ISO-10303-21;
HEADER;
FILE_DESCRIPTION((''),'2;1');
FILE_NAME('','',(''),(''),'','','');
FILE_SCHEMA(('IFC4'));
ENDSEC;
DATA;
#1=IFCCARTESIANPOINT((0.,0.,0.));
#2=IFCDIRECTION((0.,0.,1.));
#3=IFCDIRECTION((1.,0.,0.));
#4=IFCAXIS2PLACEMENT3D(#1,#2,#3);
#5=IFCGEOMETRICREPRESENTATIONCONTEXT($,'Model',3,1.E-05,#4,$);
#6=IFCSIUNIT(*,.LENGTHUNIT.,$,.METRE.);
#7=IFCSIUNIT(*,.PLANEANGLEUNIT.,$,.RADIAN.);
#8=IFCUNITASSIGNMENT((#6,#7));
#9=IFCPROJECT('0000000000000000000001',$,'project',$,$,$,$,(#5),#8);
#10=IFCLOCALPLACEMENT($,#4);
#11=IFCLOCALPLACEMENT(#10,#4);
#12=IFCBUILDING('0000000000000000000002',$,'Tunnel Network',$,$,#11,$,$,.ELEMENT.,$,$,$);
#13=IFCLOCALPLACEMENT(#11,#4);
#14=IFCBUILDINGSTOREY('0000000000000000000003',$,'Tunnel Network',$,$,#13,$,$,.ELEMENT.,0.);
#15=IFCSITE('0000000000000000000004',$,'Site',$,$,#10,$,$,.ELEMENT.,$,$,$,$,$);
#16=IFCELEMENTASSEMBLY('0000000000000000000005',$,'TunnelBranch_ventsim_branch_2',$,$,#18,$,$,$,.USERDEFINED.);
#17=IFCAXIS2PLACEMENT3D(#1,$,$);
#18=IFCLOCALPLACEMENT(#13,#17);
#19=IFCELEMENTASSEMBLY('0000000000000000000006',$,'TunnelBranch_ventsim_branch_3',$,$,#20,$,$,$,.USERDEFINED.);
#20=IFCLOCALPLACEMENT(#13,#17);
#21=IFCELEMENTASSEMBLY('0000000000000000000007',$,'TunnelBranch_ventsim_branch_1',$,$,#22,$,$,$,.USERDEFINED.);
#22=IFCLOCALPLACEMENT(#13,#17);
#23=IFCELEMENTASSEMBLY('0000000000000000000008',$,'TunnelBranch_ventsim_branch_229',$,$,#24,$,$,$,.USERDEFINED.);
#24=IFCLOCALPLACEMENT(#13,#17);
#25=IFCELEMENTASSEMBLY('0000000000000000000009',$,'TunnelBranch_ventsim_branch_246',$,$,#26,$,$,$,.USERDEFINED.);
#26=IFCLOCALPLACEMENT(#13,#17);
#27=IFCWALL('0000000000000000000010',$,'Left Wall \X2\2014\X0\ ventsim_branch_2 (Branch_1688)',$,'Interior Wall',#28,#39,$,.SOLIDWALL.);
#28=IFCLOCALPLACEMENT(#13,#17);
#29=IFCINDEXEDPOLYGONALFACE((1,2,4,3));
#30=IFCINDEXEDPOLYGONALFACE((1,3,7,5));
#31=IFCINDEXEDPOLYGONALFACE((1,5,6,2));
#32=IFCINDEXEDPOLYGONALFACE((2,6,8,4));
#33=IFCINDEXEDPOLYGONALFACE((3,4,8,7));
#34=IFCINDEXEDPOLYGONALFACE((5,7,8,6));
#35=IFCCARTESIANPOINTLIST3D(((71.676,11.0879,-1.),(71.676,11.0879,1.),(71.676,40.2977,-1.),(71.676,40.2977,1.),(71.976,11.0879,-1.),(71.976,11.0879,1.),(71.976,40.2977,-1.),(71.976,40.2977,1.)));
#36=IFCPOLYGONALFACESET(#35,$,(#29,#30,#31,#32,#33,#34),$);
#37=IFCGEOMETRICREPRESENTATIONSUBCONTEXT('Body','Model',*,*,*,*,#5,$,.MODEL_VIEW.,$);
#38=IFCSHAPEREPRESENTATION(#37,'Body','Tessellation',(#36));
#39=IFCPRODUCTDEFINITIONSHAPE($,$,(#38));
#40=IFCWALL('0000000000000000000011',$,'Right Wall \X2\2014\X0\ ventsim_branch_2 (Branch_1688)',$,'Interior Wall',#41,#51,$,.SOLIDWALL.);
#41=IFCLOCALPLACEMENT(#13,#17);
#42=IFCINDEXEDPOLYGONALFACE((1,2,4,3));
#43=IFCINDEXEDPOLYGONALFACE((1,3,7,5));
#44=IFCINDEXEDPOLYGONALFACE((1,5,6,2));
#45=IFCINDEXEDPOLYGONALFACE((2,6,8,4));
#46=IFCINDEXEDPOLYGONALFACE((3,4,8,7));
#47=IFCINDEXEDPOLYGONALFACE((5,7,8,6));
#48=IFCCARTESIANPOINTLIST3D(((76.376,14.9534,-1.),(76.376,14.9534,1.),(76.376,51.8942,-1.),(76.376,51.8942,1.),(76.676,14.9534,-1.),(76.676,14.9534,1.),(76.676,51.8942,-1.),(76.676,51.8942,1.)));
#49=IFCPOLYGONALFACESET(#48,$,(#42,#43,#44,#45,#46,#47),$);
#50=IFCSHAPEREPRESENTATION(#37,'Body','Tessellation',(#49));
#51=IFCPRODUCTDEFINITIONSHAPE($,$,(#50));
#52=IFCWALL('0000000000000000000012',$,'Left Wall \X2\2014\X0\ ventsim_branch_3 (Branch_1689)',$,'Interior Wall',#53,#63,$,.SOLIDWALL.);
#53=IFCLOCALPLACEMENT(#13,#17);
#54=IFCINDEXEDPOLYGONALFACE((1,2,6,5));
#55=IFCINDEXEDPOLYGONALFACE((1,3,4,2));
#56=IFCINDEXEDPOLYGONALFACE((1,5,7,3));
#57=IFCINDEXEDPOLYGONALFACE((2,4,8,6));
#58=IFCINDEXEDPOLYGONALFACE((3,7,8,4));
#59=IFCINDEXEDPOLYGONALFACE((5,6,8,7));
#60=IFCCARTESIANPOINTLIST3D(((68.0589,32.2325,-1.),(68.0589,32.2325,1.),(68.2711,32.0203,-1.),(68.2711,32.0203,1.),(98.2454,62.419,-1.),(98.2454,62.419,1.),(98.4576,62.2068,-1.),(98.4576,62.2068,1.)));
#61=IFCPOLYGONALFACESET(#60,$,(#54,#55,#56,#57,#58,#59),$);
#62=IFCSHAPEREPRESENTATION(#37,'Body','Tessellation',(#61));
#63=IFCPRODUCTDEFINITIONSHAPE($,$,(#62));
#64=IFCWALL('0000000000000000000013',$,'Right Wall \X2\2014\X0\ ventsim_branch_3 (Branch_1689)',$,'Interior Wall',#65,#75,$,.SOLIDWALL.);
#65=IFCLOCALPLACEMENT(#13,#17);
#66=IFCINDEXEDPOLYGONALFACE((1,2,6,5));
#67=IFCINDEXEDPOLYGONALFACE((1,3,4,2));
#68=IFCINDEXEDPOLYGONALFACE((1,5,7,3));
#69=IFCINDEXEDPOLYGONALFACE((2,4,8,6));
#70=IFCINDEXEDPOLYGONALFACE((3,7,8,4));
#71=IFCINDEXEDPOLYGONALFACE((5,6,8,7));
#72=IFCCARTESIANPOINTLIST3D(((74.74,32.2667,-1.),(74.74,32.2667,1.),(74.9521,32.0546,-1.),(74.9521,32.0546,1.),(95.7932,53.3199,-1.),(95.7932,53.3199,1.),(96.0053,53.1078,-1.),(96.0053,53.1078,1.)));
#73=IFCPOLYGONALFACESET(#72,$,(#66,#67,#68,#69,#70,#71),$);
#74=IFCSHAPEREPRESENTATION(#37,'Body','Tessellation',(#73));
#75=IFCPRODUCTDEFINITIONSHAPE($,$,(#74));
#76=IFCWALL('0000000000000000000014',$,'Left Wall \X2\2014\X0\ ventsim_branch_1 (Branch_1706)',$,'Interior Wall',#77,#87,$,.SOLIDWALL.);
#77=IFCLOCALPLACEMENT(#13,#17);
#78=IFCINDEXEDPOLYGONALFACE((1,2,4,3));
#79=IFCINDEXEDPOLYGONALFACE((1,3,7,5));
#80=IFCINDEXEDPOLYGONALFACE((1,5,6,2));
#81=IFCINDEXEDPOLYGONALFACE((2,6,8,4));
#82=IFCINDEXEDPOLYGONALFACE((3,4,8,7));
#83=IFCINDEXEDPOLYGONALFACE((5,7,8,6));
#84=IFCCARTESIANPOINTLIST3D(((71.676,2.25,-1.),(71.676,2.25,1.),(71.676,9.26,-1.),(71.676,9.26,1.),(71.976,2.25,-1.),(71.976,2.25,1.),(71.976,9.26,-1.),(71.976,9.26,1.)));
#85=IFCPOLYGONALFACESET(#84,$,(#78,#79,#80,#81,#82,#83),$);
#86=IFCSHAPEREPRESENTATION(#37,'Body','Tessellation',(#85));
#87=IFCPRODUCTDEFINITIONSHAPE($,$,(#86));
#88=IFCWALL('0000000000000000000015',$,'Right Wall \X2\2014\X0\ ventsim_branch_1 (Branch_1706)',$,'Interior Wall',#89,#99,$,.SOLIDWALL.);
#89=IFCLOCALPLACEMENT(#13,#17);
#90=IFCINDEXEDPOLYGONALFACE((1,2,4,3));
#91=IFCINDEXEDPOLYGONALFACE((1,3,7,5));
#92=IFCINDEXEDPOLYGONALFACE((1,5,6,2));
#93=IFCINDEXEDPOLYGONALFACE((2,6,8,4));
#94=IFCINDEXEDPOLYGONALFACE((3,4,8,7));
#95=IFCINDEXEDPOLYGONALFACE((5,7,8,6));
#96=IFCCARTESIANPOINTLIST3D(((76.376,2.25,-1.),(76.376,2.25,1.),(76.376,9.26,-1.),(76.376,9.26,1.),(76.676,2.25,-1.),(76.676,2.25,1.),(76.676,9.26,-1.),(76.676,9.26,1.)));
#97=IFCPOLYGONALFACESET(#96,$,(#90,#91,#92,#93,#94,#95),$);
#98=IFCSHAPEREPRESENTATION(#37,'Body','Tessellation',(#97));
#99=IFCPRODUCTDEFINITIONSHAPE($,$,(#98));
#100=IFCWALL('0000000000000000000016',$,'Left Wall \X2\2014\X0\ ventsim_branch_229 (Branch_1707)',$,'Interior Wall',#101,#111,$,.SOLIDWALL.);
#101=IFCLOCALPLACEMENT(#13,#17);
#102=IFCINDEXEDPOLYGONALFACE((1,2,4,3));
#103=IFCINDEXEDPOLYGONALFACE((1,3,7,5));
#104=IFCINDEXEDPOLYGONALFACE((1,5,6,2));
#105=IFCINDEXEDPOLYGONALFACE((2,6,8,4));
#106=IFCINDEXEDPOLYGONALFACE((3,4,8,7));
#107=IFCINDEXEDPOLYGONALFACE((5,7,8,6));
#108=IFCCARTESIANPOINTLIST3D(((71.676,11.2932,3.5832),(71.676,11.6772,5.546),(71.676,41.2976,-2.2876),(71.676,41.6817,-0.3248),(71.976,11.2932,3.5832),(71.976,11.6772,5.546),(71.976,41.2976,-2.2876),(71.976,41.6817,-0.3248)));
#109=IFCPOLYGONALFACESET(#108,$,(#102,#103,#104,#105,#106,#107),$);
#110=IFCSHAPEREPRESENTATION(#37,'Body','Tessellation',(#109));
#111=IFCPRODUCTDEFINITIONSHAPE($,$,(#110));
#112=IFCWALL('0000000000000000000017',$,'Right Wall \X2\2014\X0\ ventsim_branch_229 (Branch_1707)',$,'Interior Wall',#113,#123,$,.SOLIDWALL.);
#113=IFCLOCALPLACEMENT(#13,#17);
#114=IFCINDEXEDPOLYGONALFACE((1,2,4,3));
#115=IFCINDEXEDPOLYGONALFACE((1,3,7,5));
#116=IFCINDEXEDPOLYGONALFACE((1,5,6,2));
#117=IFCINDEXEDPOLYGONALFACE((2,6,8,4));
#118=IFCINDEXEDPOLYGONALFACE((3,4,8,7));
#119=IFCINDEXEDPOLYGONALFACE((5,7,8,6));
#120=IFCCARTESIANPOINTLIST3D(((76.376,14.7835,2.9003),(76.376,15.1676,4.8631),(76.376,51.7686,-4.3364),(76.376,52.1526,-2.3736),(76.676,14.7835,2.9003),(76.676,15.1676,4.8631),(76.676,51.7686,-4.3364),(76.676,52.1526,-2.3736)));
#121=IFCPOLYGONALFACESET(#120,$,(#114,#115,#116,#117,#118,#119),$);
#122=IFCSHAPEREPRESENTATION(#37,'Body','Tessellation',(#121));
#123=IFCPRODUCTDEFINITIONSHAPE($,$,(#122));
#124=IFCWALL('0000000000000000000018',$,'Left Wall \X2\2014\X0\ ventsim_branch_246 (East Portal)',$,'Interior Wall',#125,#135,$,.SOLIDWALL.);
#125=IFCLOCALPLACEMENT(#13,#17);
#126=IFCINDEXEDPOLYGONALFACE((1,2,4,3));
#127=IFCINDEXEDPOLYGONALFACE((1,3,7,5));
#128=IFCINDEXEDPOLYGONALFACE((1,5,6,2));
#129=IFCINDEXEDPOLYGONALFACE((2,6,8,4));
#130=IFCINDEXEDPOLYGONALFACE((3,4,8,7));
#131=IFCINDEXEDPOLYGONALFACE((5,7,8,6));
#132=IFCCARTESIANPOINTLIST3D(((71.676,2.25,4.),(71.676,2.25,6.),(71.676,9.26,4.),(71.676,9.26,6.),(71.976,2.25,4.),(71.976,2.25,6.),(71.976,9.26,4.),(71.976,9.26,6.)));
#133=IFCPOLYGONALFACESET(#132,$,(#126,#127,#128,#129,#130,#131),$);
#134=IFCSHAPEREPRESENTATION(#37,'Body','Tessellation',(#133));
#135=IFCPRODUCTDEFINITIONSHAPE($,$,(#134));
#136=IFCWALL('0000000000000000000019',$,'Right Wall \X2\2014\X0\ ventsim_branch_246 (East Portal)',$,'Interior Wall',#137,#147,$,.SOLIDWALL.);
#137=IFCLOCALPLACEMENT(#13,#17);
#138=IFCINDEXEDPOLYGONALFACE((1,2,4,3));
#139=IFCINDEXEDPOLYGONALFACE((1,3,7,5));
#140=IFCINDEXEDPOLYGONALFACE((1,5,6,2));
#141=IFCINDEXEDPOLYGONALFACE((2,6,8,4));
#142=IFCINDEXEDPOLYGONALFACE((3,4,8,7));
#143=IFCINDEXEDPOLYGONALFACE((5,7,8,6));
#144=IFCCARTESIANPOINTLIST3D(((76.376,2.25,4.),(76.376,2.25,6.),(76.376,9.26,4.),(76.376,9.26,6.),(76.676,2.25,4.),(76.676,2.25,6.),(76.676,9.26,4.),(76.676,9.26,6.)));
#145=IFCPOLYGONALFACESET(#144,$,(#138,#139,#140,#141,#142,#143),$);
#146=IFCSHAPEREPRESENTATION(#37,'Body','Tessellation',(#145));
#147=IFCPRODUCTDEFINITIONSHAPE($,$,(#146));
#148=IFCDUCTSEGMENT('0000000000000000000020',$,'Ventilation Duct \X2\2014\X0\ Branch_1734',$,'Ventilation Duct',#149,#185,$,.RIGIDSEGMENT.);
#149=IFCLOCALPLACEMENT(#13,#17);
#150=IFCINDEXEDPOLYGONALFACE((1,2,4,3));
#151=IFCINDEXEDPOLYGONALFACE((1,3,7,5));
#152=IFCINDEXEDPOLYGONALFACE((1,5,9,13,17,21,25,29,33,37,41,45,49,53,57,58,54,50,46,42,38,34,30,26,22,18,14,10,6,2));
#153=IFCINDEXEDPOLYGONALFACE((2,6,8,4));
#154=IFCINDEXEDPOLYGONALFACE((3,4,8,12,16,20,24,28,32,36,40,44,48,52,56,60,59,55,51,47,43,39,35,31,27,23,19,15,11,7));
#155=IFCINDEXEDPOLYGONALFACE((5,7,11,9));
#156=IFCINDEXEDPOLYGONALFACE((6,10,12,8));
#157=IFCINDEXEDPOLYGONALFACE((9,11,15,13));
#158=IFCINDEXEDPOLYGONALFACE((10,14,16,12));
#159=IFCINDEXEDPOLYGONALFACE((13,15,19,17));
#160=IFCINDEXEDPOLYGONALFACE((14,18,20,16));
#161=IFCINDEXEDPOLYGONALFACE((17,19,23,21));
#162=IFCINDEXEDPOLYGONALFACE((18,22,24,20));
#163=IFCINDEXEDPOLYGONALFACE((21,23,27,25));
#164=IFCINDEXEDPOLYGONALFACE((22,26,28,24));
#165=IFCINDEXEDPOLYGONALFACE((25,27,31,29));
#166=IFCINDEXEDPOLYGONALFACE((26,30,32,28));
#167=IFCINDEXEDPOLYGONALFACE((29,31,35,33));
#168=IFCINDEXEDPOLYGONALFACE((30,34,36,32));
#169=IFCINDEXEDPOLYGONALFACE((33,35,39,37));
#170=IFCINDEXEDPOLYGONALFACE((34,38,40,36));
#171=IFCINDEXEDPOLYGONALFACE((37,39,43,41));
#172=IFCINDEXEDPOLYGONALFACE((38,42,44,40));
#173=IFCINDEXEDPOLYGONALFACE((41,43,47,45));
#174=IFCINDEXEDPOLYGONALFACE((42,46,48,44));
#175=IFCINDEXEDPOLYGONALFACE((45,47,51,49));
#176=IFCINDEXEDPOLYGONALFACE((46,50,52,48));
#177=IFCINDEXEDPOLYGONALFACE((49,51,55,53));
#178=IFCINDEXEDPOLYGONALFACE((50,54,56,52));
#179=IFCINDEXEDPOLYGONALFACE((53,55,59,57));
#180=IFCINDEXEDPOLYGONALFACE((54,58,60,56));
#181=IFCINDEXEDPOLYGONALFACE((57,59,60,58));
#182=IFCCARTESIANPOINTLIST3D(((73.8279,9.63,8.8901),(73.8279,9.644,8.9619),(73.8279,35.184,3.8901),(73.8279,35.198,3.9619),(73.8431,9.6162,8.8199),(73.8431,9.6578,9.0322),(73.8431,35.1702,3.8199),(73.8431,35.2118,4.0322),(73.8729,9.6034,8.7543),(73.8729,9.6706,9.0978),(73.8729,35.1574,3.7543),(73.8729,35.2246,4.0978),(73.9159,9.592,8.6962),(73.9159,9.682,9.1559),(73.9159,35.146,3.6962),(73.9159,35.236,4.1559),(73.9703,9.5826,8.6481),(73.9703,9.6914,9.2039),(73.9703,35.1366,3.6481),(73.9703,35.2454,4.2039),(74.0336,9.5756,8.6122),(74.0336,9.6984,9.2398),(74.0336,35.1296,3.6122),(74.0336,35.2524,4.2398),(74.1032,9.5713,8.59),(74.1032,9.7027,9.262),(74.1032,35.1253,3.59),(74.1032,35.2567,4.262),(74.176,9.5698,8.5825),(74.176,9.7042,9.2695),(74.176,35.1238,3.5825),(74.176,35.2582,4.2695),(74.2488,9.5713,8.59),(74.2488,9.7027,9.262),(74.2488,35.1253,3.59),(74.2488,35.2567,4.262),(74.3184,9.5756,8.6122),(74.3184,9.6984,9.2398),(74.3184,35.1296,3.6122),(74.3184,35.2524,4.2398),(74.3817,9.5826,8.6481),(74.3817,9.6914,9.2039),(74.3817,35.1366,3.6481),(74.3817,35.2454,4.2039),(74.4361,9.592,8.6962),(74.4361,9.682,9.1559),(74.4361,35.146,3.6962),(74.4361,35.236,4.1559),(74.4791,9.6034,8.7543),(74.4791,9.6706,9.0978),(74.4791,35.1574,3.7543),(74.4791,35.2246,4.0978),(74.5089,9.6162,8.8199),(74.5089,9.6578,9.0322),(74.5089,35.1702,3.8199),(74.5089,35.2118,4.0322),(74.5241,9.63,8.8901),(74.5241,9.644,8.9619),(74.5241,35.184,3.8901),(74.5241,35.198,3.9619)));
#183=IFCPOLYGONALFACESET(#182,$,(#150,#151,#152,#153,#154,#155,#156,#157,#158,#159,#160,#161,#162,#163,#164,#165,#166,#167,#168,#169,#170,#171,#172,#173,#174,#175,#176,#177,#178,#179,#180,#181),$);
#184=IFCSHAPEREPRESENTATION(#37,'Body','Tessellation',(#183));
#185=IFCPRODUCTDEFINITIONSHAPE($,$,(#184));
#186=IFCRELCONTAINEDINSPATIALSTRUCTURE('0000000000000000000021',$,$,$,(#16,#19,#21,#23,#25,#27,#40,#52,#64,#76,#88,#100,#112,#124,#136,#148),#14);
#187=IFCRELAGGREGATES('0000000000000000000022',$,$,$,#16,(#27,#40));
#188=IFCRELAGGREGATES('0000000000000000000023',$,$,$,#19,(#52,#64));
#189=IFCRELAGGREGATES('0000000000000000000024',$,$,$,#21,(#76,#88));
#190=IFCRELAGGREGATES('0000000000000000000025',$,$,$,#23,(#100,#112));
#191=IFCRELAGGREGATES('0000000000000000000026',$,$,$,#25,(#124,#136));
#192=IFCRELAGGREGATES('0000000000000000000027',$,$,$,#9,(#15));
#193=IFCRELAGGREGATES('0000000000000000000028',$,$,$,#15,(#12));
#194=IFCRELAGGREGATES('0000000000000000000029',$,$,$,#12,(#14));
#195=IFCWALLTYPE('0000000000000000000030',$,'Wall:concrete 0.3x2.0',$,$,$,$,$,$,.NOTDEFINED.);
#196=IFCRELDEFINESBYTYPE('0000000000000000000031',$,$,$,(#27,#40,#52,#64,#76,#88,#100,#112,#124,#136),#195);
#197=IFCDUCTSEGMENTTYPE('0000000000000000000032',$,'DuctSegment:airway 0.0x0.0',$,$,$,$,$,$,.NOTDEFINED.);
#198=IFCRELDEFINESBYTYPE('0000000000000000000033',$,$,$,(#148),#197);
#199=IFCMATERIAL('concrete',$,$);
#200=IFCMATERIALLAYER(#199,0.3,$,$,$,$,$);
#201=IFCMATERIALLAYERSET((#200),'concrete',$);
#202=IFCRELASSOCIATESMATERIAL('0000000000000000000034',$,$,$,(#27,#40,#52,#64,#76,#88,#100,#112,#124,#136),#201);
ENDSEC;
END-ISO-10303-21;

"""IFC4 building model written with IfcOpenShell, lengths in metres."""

from ifc_helpers import new_model, si_unit, frame, origin_with_axes, origin_2d_with_axis, place, context, subcontext, project, spatial, rectangle, circle, extrude, material, layer, layer_set, layer_usage, type_object, element, aggregate, save


model = new_model("IFC4")

# Units and contexts
model_context = context("Model", 3, precision=1e-05, world=origin_with_axes())
body_context = subcontext(model_context, "Body", "Model", "MODEL_VIEW")
ifc_project = project(units=[si_unit("LENGTHUNIT", "METRE"), si_unit("PLANEANGLEUNIT", "RADIAN")], contexts=[model_context])

# Site, building, storey
site_placement = place(None, origin_with_axes())
site = spatial("IfcSite", under=ifc_project, at=site_placement, Name="Site", CompositionType="ELEMENT")
building_placement = place(site_placement, origin_with_axes())
building = spatial("IfcBuilding", under=site, at=building_placement, Name="Tunnel Network", CompositionType="ELEMENT")
storey_placement = place(building_placement, origin_with_axes())
storey = spatial("IfcBuildingStorey", under=building, at=storey_placement, Name="Tunnel Network", CompositionType="ELEMENT", Elevation=0.0)

# Element assemblies
assembly_1_placement = place(storey_placement, frame((71.826, 11.0879, 0.0), z_axis=(0.0, 1.0, 0.0), x_axis=(1.0, 0.0, 0.0)))
assembly_1 = element("IfcElementAssembly", 1, at=assembly_1_placement, inside=storey, Name="TunnelBranch_ventsim_branch_2", PredefinedType="USERDEFINED")
ifc_material_1 = material(Name="concrete")
ifc_layer_1 = layer(ifc_material_1, 0.3)
ifc_layer_set_1 = layer_set([ifc_layer_1], Name="concrete")
assembly_2_placement = place(storey_placement, frame((68.165, 32.1264, 0.0), z_axis=(0.707107, 0.707107, 0.0), x_axis=(0.707107, -0.707107, 0.0)))
assembly_2 = element("IfcElementAssembly", 2, at=assembly_2_placement, inside=storey, Name="TunnelBranch_ventsim_branch_3", PredefinedType="USERDEFINED")
assembly_3_placement = place(storey_placement, frame((71.826, 2.25, 0.0), z_axis=(0.0, 1.0, 0.0), x_axis=(1.0, 0.0, 0.0)))
assembly_3 = element("IfcElementAssembly", 3, at=assembly_3_placement, inside=storey, Name="TunnelBranch_ventsim_branch_1", PredefinedType="USERDEFINED")
assembly_4_placement = place(storey_placement, frame((71.826, 11.4852, 4.5646), z_axis=(0.0, 0.98139, -0.192023), x_axis=(1.0, 0.0, 0.0)))
assembly_4 = element("IfcElementAssembly", 4, at=assembly_4_placement, inside=storey, Name="TunnelBranch_ventsim_branch_229", PredefinedType="USERDEFINED")
assembly_5_placement = place(storey_placement, frame((71.826, 2.25, 5.0), z_axis=(0.0, 1.0, 0.0), x_axis=(1.0, 0.0, 0.0)))
assembly_5 = element("IfcElementAssembly", 5, at=assembly_5_placement, inside=storey, Name="TunnelBranch_ventsim_branch_246", PredefinedType="USERDEFINED")

# Walls
ifc_layer_usage_1 = layer_usage(ifc_layer_set_1, "AXIS2", "POSITIVE", 0.0)
wall_type_1 = type_object("IfcWallType", Name="Wall:concrete 0.3x2.0")
wall_1_placement = place(storey_placement, frame((71.826, 11.0879, 0.0), z_axis=(0.0, 1.0, 0.0), x_axis=(1.0, 0.0, 0.0)))
wall_1 = element("IfcWall", 6, at=wall_1_placement, inside=storey, type_object=wall_type_1, material=ifc_layer_usage_1, Name="Left Wall — ventsim_branch_2 (Branch_1688)", ObjectType="Interior Wall", PredefinedType="SOLIDWALL", context=body_context, shape_type="SweptSolid", body=[
    extrude(rectangle(XDim=0.3, YDim=2.0, at=origin_2d_with_axis()), origin_with_axes(), (0.0, 0.0, 1.0), 29.2098),
])
ifc_layer_usage_2 = layer_usage(ifc_layer_set_1, "AXIS2", "POSITIVE", 0.0)
wall_2_placement = place(storey_placement, frame((76.526, 14.9534, 0.0), z_axis=(0.0, 1.0, 0.0), x_axis=(1.0, 0.0, 0.0)))
wall_2 = element("IfcWall", 7, at=wall_2_placement, inside=storey, type_object=wall_type_1, material=ifc_layer_usage_2, Name="Right Wall — ventsim_branch_2 (Branch_1688)", ObjectType="Interior Wall", PredefinedType="SOLIDWALL", context=body_context, shape_type="SweptSolid", body=[
    extrude(rectangle(XDim=0.3, YDim=2.0, at=origin_2d_with_axis()), origin_with_axes(), (0.0, 0.0, 1.0), 36.9408),
])
aggregate(assembly_1, [wall_1, wall_2])
ifc_layer_usage_3 = layer_usage(ifc_layer_set_1, "AXIS2", "POSITIVE", 0.0)
wall_3_placement = place(storey_placement, frame((68.165, 32.1264, 0.0), z_axis=(0.707107, 0.707107, 0.0), x_axis=(0.707107, -0.707107, 0.0)))
wall_3 = element("IfcWall", 8, at=wall_3_placement, inside=storey, type_object=wall_type_1, material=ifc_layer_usage_3, Name="Left Wall — ventsim_branch_3 (Branch_1689)", ObjectType="Interior Wall", PredefinedType="SOLIDWALL", context=body_context, shape_type="SweptSolid", body=[
    extrude(rectangle(XDim=0.3, YDim=2.0, at=origin_2d_with_axis()), origin_with_axes(), (0.0, 0.0, 1.0), 42.6902),
])
ifc_layer_usage_4 = layer_usage(ifc_layer_set_1, "AXIS2", "POSITIVE", 0.0)
wall_4_placement = place(storey_placement, frame((74.8461, 32.1607, 0.0), z_axis=(0.707107, 0.707107, 0.0), x_axis=(0.707107, -0.707107, 0.0)))
wall_4 = element("IfcWall", 9, at=wall_4_placement, inside=storey, type_object=wall_type_1, material=ifc_layer_usage_4, Name="Right Wall — ventsim_branch_3 (Branch_1689)", ObjectType="Interior Wall", PredefinedType="SOLIDWALL", context=body_context, shape_type="SweptSolid", body=[
    extrude(rectangle(XDim=0.3, YDim=2.0, at=origin_2d_with_axis()), origin_with_axes(), (0.0, 0.0, 1.0), 29.7737),
])
aggregate(assembly_2, [wall_3, wall_4])
ifc_layer_usage_5 = layer_usage(ifc_layer_set_1, "AXIS2", "POSITIVE", 0.0)
wall_5_placement = place(storey_placement, frame((71.826, 2.25, 0.0), z_axis=(0.0, 1.0, 0.0), x_axis=(1.0, 0.0, 0.0)))
wall_5 = element("IfcWall", 10, at=wall_5_placement, inside=storey, type_object=wall_type_1, material=ifc_layer_usage_5, Name="Left Wall — ventsim_branch_1 (Branch_1706)", ObjectType="Interior Wall", PredefinedType="SOLIDWALL", context=body_context, shape_type="SweptSolid", body=[
    extrude(rectangle(XDim=0.3, YDim=2.0, at=origin_2d_with_axis()), origin_with_axes(), (0.0, 0.0, 1.0), 7.01),
])
ifc_layer_usage_6 = layer_usage(ifc_layer_set_1, "AXIS2", "POSITIVE", 0.0)
wall_6_placement = place(storey_placement, frame((76.526, 2.25, 0.0), z_axis=(0.0, 1.0, 0.0), x_axis=(1.0, 0.0, 0.0)))
wall_6 = element("IfcWall", 11, at=wall_6_placement, inside=storey, type_object=wall_type_1, material=ifc_layer_usage_6, Name="Right Wall — ventsim_branch_1 (Branch_1706)", ObjectType="Interior Wall", PredefinedType="SOLIDWALL", context=body_context, shape_type="SweptSolid", body=[
    extrude(rectangle(XDim=0.3, YDim=2.0, at=origin_2d_with_axis()), origin_with_axes(), (0.0, 0.0, 1.0), 7.01),
])
aggregate(assembly_3, [wall_5, wall_6])
ifc_layer_usage_7 = layer_usage(ifc_layer_set_1, "AXIS2", "POSITIVE", 0.0)
wall_7_placement = place(storey_placement, frame((71.826, 11.4852, 4.5646), z_axis=(0.0, 0.98139, -0.192023), x_axis=(1.0, 0.0, 0.0)))
wall_7 = element("IfcWall", 12, at=wall_7_placement, inside=storey, type_object=wall_type_1, material=ifc_layer_usage_7, Name="Left Wall — ventsim_branch_229 (Branch_1707)", ObjectType="Interior Wall", PredefinedType="SOLIDWALL", context=body_context, shape_type="SweptSolid", body=[
    extrude(rectangle(XDim=0.3, YDim=2.0, at=origin_2d_with_axis()), origin_with_axes(), (0.0, 0.0, 1.0), 30.5734),
])
ifc_layer_usage_8 = layer_usage(ifc_layer_set_1, "AXIS2", "POSITIVE", 0.0)
wall_8_placement = place(storey_placement, frame((76.526, 14.9755, 3.8817), z_axis=(0.0, 0.98139, -0.192023), x_axis=(1.0, 0.0, 0.0)))
wall_8 = element("IfcWall", 13, at=wall_8_placement, inside=storey, type_object=wall_type_1, material=ifc_layer_usage_8, Name="Right Wall — ventsim_branch_229 (Branch_1707)", ObjectType="Interior Wall", PredefinedType="SOLIDWALL", context=body_context, shape_type="SweptSolid", body=[
    extrude(rectangle(XDim=0.3, YDim=2.0, at=origin_2d_with_axis()), origin_with_axes(), (0.0, 0.0, 1.0), 37.6864),
])
aggregate(assembly_4, [wall_7, wall_8])
ifc_layer_usage_9 = layer_usage(ifc_layer_set_1, "AXIS2", "POSITIVE", 0.0)
wall_9_placement = place(storey_placement, frame((71.826, 2.25, 5.0), z_axis=(0.0, 1.0, 0.0), x_axis=(1.0, 0.0, 0.0)))
wall_9 = element("IfcWall", 14, at=wall_9_placement, inside=storey, type_object=wall_type_1, material=ifc_layer_usage_9, Name="Left Wall — ventsim_branch_246 (East Portal)", ObjectType="Interior Wall", PredefinedType="SOLIDWALL", context=body_context, shape_type="SweptSolid", body=[
    extrude(rectangle(XDim=0.3, YDim=2.0, at=origin_2d_with_axis()), origin_with_axes(), (0.0, 0.0, 1.0), 7.01),
])
ifc_layer_usage_10 = layer_usage(ifc_layer_set_1, "AXIS2", "POSITIVE", 0.0)
wall_10_placement = place(storey_placement, frame((76.526, 2.25, 5.0), z_axis=(0.0, 1.0, 0.0), x_axis=(1.0, 0.0, 0.0)))
wall_10 = element("IfcWall", 15, at=wall_10_placement, inside=storey, type_object=wall_type_1, material=ifc_layer_usage_10, Name="Right Wall — ventsim_branch_246 (East Portal)", ObjectType="Interior Wall", PredefinedType="SOLIDWALL", context=body_context, shape_type="SweptSolid", body=[
    extrude(rectangle(XDim=0.3, YDim=2.0, at=origin_2d_with_axis()), origin_with_axes(), (0.0, 0.0, 1.0), 7.01),
])
aggregate(assembly_5, [wall_9, wall_10])

# Duct segment
duct_segment_type = type_object("IfcDuctSegmentType", Name="DuctSegment:airway 0.0x0.0")
duct_segment_1_placement = place(storey_placement, frame((74.176, 9.637, 8.926), z_axis=(0.0, 0.98139, -0.192023), x_axis=(0.0, 0.192023, 0.98139)))
element("IfcDuctSegment", 16, at=duct_segment_1_placement, inside=storey, type_object=duct_segment_type, Name="Ventilation Duct — Branch_1734", ObjectType="Ventilation Duct", PredefinedType="RIGIDSEGMENT", context=body_context, shape_type="SweptSolid", body=[
    extrude(circle(Radius=0.35, at=origin_2d_with_axis()), origin_with_axes(), (0.0, 0.0, 1.0), 26.0386),
])

save(model, "model.ifc")
